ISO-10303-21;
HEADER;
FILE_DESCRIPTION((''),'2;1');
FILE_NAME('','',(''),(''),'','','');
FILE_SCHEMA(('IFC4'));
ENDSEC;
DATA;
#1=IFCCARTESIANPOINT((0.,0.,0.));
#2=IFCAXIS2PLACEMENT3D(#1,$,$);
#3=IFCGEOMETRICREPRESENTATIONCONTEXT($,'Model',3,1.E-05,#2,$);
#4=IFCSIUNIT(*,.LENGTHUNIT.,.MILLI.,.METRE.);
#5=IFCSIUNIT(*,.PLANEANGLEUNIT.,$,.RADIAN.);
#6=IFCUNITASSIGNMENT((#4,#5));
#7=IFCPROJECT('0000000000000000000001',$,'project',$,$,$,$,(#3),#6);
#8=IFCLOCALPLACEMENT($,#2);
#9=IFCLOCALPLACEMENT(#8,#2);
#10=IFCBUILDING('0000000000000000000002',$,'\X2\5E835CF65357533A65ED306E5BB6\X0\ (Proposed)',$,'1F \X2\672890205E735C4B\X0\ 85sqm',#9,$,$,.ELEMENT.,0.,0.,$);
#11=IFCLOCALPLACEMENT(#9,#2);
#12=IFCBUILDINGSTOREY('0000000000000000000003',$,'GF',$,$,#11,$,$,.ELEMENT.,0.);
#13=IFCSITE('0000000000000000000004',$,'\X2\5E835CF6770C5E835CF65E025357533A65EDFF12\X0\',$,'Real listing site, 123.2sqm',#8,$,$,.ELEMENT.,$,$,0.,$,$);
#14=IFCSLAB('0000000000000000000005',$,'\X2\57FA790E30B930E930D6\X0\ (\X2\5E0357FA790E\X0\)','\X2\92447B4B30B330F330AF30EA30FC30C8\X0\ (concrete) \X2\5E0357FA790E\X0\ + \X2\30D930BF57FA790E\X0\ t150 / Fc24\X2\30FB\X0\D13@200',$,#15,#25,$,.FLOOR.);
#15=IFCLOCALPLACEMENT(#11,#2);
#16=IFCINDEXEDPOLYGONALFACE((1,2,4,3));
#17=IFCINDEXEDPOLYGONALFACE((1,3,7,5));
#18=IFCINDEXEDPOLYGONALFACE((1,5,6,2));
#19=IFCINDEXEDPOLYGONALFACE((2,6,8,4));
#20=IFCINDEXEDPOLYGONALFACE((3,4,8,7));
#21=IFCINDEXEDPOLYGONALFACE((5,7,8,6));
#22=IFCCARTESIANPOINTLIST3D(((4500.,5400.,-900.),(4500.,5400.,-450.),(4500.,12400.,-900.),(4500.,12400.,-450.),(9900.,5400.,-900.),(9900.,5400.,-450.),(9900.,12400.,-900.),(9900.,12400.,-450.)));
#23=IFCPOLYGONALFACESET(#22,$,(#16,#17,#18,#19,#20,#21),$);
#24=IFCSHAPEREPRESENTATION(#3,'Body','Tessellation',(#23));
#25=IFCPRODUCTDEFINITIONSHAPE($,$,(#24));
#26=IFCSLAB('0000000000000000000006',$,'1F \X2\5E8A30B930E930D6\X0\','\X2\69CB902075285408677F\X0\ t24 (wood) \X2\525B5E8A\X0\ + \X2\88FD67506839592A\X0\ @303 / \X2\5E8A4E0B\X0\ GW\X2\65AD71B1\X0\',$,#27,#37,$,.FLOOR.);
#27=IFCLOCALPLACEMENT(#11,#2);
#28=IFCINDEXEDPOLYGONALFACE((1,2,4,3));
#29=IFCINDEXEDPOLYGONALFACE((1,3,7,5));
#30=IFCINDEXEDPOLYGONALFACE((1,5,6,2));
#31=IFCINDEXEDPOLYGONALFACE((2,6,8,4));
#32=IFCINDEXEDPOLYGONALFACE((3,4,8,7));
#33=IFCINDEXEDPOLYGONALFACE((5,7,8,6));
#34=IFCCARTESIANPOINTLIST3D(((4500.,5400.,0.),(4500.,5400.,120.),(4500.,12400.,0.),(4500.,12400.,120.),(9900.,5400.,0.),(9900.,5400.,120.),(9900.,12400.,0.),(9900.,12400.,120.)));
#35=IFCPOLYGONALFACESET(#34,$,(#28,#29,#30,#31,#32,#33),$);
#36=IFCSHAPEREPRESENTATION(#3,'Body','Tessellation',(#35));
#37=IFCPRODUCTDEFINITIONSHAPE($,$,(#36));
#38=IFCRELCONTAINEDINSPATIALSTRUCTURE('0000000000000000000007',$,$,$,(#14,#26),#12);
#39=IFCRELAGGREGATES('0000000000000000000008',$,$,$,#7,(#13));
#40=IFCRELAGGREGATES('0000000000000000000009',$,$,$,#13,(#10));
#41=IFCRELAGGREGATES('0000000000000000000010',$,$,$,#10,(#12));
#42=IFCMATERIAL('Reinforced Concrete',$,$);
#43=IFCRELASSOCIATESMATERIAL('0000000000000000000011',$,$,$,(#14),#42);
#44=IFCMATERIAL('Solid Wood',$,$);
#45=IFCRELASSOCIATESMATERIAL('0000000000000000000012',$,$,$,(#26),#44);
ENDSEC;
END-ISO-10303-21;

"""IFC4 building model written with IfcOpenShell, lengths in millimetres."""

from ifc_helpers import new_model, si_unit, frame, frame_2d, origin, place, context, project, spatial, rectangle, extrude, material, element, save


model = new_model("IFC4")

# Units and contexts
model_context = context("Model", 3, precision=1e-05, world=origin())
ifc_project = project(units=[si_unit("LENGTHUNIT", "METRE", prefix="MILLI"), si_unit("PLANEANGLEUNIT", "RADIAN")], contexts=[model_context])

# Site, building, storey
site_placement = place(None, origin())
site = spatial("IfcSite", under=ifc_project, at=site_placement, Name="広島県広島市南区旭２", ObjectType="Real listing site, 123.2sqm", CompositionType="ELEMENT", RefElevation=0.0)
building_placement = place(site_placement, origin())
building = spatial("IfcBuilding", under=site, at=building_placement, Name="広島南区旭の家 (Proposed)", ObjectType="1F 木造平屋 85sqm", CompositionType="ELEMENT", ElevationOfRefHeight=0.0, ElevationOfTerrain=0.0)
storey_placement = place(building_placement, origin())
storey = spatial("IfcBuildingStorey", under=building, at=storey_placement, Name="GF", CompositionType="ELEMENT", Elevation=0.0)

# Slabs
ifc_material_1 = material(Name="Reinforced Concrete")
slab_1_placement = place(storey_placement, frame((2250.0, 2700.0, -450.0)))
element("IfcSlab", 1, at=slab_1_placement, inside=storey, material=ifc_material_1, Name="基礎スラブ (布基礎)", Description="鉄筋コンクリート (concrete) 布基礎 + ベタ基礎 t150 / Fc24・D13@200", PredefinedType="FLOOR", context=model_context, shape_type="SweptSolid", body=[
    extrude(rectangle(XDim=5400.0, YDim=7000.0, at=frame_2d((2700.0, 3500.0))), frame((2250.0, 2700.0, -450.0)), (0.0, 0.0, 1.0), 450.0),
])
ifc_material_2 = material(Name="Solid Wood")
slab_2_placement = place(storey_placement, frame((2250.0, 2700.0, 0.0)))
element("IfcSlab", 2, at=slab_2_placement, inside=storey, material=ifc_material_2, Name="1F 床スラブ", Description="構造用合板 t24 (wood) 剛床 + 製材根太 @303 / 床下 GW断熱", PredefinedType="FLOOR", context=model_context, shape_type="SweptSolid", body=[
    extrude(rectangle(XDim=5400.0, YDim=7000.0, at=frame_2d((2700.0, 3500.0))), frame((2250.0, 2700.0, 0.0)), (0.0, 0.0, 1.0), 120.0),
])

save(model, "model.ifc")
